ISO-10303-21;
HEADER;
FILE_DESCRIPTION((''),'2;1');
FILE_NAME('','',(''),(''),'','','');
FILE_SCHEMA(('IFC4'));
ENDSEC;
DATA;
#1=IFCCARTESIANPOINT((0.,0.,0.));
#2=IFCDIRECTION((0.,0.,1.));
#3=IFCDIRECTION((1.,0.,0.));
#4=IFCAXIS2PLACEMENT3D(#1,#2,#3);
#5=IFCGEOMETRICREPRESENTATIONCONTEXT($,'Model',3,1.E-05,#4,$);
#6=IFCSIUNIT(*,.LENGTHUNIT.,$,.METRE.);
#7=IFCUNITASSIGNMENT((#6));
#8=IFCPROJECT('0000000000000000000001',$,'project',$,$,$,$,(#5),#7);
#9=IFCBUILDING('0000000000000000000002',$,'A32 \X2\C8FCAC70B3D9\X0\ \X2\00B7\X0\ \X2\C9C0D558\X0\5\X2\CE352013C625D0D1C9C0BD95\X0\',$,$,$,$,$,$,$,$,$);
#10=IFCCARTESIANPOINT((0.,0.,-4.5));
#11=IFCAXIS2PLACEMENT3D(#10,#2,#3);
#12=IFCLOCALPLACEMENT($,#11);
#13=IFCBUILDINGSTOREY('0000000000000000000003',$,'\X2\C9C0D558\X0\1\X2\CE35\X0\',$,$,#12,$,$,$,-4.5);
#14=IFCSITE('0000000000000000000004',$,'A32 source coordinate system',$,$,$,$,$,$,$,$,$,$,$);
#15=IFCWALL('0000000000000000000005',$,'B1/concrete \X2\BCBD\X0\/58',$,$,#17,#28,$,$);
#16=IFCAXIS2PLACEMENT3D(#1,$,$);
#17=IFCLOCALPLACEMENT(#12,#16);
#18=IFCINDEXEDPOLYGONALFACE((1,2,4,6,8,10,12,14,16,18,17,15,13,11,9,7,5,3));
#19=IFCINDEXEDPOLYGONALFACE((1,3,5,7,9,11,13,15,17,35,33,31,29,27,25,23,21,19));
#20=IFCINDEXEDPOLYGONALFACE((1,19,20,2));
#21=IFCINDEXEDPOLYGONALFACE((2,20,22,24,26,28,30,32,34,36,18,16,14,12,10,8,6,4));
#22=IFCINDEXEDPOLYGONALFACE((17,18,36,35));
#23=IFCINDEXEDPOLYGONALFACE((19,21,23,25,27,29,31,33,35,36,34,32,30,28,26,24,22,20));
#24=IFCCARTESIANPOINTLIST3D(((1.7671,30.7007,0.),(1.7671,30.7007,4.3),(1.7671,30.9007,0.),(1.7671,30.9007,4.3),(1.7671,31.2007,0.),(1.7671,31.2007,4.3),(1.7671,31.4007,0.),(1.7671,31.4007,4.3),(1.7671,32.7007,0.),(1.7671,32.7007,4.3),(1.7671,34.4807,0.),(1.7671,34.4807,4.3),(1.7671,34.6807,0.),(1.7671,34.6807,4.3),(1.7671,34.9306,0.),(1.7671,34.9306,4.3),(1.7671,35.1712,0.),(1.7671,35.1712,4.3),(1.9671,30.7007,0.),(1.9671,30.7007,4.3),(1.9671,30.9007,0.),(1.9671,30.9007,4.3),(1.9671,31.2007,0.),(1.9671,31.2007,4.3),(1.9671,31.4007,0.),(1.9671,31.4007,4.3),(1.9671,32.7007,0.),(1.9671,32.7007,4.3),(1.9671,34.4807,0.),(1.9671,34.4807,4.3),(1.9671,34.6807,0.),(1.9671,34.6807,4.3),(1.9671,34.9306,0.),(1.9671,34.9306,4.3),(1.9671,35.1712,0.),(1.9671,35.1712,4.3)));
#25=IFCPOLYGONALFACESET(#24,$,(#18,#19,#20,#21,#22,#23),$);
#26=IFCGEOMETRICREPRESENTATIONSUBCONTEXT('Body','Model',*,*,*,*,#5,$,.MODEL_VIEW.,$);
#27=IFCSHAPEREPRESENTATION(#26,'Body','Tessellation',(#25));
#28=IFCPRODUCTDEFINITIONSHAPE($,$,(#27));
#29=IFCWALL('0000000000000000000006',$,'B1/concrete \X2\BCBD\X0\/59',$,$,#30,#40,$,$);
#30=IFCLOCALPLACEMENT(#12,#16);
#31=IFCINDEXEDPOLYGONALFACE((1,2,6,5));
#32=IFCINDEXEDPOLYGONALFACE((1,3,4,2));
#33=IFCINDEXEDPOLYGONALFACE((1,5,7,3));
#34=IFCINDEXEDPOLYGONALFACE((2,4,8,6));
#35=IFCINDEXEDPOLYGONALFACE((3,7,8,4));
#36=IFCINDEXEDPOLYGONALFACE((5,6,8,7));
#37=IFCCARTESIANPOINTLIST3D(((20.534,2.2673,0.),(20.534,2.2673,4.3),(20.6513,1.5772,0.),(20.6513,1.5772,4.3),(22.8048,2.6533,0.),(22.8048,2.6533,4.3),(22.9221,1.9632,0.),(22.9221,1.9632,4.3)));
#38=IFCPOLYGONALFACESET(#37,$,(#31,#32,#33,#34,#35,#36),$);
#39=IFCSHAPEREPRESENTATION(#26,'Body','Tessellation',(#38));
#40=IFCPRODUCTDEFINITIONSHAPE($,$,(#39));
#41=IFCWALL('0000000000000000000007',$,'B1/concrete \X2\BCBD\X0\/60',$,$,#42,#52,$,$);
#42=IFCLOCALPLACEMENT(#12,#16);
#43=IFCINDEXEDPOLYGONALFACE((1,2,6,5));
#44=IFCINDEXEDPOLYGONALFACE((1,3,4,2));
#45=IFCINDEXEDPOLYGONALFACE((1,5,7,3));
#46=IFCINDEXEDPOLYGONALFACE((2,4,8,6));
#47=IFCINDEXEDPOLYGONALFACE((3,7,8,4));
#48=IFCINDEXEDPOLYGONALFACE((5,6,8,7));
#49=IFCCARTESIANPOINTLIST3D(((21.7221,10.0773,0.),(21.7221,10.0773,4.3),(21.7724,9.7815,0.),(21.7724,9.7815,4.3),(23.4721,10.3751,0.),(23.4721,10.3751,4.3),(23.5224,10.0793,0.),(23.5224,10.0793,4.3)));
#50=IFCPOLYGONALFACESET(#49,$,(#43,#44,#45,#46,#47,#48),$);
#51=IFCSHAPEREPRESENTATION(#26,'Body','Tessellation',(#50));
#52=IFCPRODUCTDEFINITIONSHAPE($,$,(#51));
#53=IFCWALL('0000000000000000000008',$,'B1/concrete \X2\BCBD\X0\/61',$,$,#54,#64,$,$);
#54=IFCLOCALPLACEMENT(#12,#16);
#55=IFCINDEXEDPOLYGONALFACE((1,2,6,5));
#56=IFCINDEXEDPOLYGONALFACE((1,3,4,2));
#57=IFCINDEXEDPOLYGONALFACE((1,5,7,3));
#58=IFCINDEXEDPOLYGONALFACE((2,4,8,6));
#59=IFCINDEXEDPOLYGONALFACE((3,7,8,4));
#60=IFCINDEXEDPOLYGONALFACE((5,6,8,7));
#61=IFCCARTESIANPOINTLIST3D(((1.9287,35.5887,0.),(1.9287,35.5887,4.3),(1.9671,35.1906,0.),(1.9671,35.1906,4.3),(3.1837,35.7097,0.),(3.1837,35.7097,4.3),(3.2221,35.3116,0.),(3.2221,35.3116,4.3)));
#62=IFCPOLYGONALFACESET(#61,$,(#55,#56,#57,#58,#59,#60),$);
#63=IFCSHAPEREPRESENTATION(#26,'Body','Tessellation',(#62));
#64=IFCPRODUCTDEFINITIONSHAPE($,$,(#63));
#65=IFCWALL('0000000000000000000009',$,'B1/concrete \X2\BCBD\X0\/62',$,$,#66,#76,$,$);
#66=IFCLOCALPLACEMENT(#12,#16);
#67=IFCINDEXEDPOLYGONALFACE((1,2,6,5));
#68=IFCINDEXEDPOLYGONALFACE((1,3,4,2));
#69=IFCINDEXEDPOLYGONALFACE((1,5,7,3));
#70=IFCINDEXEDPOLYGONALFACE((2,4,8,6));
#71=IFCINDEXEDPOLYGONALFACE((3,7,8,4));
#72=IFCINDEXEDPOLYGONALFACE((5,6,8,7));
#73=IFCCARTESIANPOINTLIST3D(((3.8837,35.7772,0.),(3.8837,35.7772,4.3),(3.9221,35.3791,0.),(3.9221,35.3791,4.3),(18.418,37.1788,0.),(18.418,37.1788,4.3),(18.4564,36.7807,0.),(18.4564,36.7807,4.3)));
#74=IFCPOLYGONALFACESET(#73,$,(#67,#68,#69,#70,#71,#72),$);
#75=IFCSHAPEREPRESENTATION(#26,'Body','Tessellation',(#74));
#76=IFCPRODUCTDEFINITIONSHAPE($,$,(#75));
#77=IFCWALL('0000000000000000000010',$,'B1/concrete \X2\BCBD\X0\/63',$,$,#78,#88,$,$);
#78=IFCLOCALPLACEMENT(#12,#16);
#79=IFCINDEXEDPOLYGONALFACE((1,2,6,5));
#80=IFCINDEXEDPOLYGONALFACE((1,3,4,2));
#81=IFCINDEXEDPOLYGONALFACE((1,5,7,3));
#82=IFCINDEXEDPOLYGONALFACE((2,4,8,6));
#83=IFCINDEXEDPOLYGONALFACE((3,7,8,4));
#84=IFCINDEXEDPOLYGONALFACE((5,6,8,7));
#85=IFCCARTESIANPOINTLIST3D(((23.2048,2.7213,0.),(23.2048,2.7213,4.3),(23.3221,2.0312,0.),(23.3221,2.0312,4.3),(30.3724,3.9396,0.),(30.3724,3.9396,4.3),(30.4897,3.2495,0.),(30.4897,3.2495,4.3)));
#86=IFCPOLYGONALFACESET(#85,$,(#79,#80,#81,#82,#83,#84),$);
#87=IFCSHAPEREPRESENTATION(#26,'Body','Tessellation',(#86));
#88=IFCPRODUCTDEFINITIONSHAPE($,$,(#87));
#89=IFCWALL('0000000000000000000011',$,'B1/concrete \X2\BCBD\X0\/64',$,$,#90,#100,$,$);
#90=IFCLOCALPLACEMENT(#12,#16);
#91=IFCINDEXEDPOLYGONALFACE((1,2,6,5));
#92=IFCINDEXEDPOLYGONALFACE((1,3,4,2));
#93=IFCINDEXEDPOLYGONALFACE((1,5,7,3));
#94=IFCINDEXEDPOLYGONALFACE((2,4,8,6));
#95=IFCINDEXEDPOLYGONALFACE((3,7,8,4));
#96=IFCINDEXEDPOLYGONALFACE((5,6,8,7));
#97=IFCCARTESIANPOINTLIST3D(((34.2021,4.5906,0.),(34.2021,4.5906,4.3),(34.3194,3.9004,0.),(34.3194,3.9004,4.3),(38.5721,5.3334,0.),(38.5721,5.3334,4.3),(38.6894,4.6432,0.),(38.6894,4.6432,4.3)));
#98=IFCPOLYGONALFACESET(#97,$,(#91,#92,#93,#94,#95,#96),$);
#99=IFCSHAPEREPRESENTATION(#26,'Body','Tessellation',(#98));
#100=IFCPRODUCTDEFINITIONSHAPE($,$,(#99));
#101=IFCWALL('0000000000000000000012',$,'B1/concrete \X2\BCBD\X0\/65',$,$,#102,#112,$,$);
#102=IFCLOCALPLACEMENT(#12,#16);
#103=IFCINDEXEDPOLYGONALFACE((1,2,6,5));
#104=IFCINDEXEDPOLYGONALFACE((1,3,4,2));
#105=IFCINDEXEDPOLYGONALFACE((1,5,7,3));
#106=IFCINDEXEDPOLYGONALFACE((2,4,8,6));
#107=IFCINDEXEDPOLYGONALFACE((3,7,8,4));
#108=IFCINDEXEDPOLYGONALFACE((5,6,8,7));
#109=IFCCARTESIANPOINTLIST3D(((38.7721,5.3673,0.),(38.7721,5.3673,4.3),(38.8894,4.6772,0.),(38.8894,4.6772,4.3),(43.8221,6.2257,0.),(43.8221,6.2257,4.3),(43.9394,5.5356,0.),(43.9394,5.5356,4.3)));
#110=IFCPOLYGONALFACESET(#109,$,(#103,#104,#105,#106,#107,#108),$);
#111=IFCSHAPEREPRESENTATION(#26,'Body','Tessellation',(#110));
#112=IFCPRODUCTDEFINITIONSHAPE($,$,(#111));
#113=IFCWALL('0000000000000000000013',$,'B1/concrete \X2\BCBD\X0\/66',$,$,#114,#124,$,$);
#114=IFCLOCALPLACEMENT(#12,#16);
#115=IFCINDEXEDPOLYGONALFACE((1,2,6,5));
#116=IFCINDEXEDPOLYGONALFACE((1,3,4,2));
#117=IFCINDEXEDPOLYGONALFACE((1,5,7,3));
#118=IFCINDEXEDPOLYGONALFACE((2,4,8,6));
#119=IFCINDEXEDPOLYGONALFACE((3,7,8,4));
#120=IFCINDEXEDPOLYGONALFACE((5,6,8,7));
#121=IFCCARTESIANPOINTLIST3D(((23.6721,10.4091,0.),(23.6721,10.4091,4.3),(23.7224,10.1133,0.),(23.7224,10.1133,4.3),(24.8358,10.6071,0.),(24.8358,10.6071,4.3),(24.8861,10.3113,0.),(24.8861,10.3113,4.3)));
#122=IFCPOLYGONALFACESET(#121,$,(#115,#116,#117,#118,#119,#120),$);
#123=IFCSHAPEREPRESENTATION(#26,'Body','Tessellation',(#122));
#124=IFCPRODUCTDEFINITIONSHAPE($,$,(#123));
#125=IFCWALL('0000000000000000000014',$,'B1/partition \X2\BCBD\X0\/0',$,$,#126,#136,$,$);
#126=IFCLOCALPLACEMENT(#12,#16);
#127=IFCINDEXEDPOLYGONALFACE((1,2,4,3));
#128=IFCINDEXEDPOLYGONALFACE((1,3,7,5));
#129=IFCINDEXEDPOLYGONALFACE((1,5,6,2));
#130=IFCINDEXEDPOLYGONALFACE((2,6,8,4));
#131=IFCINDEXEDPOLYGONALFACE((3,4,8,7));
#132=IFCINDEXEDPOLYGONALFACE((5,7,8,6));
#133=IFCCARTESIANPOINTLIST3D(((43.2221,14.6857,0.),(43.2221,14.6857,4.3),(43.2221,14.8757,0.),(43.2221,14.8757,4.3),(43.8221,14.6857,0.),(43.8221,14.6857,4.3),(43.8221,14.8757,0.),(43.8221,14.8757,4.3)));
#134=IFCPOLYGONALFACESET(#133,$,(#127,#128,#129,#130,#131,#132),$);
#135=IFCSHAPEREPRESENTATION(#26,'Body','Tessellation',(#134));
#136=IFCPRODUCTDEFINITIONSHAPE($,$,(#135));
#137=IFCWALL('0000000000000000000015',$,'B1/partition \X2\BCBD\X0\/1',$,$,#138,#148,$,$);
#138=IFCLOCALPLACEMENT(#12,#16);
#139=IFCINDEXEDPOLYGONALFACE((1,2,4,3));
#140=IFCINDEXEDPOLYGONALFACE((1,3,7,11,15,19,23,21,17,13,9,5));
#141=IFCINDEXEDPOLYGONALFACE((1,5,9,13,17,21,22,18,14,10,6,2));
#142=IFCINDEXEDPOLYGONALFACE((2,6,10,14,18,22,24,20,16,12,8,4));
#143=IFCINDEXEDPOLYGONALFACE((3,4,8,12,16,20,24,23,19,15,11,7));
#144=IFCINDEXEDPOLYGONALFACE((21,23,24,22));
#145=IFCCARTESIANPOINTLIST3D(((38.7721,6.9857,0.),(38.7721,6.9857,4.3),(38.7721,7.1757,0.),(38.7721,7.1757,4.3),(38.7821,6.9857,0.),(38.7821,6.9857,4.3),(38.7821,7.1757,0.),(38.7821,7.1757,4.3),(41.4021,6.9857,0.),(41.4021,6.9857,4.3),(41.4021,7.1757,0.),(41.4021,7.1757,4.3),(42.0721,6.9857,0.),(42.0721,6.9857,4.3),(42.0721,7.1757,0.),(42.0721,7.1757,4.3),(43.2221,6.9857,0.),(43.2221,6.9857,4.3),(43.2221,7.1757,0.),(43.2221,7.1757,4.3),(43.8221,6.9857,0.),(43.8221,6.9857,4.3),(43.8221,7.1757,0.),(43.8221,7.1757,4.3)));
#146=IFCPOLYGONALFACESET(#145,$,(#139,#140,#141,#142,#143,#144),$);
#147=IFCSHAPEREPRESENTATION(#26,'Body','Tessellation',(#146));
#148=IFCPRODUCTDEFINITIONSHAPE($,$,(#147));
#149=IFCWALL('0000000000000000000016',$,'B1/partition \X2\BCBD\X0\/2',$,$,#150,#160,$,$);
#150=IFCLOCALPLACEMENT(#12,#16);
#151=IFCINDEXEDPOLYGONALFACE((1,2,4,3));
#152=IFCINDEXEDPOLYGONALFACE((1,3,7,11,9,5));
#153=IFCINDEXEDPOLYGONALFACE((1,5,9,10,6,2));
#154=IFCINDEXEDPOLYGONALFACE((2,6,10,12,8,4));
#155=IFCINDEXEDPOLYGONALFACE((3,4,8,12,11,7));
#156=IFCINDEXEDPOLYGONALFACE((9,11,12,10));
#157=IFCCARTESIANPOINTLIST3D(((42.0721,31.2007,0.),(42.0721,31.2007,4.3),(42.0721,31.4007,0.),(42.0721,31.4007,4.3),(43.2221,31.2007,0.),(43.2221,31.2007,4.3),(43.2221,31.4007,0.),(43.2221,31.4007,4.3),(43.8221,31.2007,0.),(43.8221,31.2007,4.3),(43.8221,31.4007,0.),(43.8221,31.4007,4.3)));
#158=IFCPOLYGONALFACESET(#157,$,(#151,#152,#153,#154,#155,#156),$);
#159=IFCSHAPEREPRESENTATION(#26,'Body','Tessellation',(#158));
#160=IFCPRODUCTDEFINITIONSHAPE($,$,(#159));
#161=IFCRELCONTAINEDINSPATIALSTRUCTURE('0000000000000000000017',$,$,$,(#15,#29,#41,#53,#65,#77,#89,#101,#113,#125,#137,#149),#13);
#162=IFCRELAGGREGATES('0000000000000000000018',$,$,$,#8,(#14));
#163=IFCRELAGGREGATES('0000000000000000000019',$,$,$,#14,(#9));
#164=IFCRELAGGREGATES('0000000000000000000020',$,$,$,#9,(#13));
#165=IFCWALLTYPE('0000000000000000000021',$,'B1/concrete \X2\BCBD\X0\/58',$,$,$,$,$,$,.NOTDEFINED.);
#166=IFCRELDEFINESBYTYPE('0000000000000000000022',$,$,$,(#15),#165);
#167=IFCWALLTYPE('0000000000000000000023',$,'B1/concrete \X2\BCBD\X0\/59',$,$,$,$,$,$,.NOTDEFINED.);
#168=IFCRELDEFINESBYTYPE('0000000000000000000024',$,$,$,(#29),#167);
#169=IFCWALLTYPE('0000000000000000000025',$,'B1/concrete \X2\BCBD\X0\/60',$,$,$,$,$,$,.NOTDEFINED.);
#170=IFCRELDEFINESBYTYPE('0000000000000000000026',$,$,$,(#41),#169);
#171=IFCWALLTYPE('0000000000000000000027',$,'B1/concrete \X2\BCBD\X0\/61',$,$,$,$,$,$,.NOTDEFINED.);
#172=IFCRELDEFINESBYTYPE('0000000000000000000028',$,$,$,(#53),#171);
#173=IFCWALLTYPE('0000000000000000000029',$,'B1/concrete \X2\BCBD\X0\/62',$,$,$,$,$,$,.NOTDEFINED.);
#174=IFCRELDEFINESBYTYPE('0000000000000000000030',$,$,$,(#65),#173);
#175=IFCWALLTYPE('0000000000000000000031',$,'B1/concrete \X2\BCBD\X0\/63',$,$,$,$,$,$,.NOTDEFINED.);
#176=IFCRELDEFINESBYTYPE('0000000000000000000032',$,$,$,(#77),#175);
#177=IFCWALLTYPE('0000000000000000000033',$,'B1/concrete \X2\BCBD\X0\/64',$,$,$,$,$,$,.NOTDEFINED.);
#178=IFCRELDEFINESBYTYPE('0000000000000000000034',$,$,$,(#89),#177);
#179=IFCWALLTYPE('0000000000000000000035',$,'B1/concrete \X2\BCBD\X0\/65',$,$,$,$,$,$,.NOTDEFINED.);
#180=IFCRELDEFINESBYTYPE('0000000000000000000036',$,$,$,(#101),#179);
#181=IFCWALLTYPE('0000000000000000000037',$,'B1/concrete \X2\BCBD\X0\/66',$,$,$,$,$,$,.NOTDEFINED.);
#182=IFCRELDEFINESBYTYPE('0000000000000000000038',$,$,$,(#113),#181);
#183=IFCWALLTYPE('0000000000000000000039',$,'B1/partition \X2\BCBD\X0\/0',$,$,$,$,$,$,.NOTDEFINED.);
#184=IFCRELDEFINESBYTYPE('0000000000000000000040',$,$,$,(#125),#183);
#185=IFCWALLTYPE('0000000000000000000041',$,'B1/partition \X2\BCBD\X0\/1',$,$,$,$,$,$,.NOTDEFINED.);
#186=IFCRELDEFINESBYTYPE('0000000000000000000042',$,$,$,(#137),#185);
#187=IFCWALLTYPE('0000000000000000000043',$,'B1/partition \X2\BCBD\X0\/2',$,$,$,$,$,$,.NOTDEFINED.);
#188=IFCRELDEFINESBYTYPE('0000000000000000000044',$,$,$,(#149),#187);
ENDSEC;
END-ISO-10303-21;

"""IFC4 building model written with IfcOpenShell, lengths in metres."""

from ifc_helpers import new_model, si_unit, frame, origin, origin_with_axes, place, context, subcontext, project, spatial, polyline, outline, extrude, source, transform, mapped, type_object, type_shapes, element, save


model = new_model("IFC4")

# Units and contexts
model_context = context("Model", 3, precision=1e-05, world=origin_with_axes())
body_context = subcontext(model_context, "Body", "Model", "MODEL_VIEW")
ifc_project = project(units=[si_unit("LENGTHUNIT", "METRE")], contexts=[model_context])

# Site, building, storey
site = spatial("IfcSite", under=ifc_project, Name="A32 source coordinate system")
building = spatial("IfcBuilding", under=site, Name="A32 주거동 · 지하5층–옥탑지붕")
storey_placement = place(None, frame((0.0, 0.0, -4.5), z_axis=(0.0, 0.0, 1.0), x_axis=(1.0, 0.0, 0.0)))
storey = spatial("IfcBuildingStorey", under=building, at=storey_placement, Name="지하1층", Elevation=-4.5)

# Walls
wall_type_1 = type_object("IfcWallType", Name="B1/concrete 벽/58", PredefinedType="NOTDEFINED")
shared_shape_1 = source(origin(), body_context, "Body", "SweptSolid", [
    extrude(outline(polyline([(1.7671, 35.1712), (1.9671, 35.1712), (1.9671, 34.9306), (1.9671, 34.6807), (1.9671, 34.4807), (1.9671, 32.7007), (1.9671, 31.4007), (1.9671, 31.2007), (1.9671, 30.9007), (1.9671, 30.7007), (1.7671, 30.7007), (1.7671, 30.9007), (1.7671, 31.2007), (1.7671, 31.4007), (1.7671, 32.7007), (1.7671, 34.4807), (1.7671, 34.6807), (1.7671, 34.9306), (1.7671, 35.1712)])), origin(), (0.0, 0.0, 1.0), 4.3),
])
type_shapes(wall_type_1, [shared_shape_1])
wall_1_placement = place(storey_placement, origin_with_axes())
element("IfcWall", 1, at=wall_1_placement, inside=storey, type_object=wall_type_1, Name="B1/concrete 벽/58", context=body_context, shape_type="MappedRepresentation", body=[
    mapped(shared_shape_1, transform((0.0, 0.0, 0.0), scale=1.0)),
])
wall_type_2 = type_object("IfcWallType", Name="B1/concrete 벽/59", PredefinedType="NOTDEFINED")
shared_shape_2 = source(origin(), body_context, "Body", "SweptSolid", [
    extrude(outline(polyline([(22.8048, 2.6533), (22.9221, 1.9632), (20.6513, 1.5772), (20.534, 2.2673), (22.8048, 2.6533)])), origin(), (0.0, 0.0, 1.0), 4.3),
])
type_shapes(wall_type_2, [shared_shape_2])
wall_2_placement = place(storey_placement, origin_with_axes())
element("IfcWall", 2, at=wall_2_placement, inside=storey, type_object=wall_type_2, Name="B1/concrete 벽/59", context=body_context, shape_type="MappedRepresentation", body=[
    mapped(shared_shape_2, transform((0.0, 0.0, 0.0), scale=1.0)),
])
wall_type_3 = type_object("IfcWallType", Name="B1/concrete 벽/60", PredefinedType="NOTDEFINED")
shared_shape_3 = source(origin(), body_context, "Body", "SweptSolid", [
    extrude(outline(polyline([(21.7221, 10.0773), (23.4721, 10.3751), (23.5224, 10.0793), (21.7724, 9.7815), (21.7221, 10.0773)])), origin(), (0.0, 0.0, 1.0), 4.3),
])
type_shapes(wall_type_3, [shared_shape_3])
wall_3_placement = place(storey_placement, origin_with_axes())
element("IfcWall", 3, at=wall_3_placement, inside=storey, type_object=wall_type_3, Name="B1/concrete 벽/60", context=body_context, shape_type="MappedRepresentation", body=[
    mapped(shared_shape_3, transform((0.0, 0.0, 0.0), scale=1.0)),
])
wall_type_4 = type_object("IfcWallType", Name="B1/concrete 벽/61", PredefinedType="NOTDEFINED")
shared_shape_4 = source(origin(), body_context, "Body", "SweptSolid", [
    extrude(outline(polyline([(1.9671, 35.1906), (1.9287, 35.5887), (3.1837, 35.7097), (3.2221, 35.3116), (1.9671, 35.1906)])), origin(), (0.0, 0.0, 1.0), 4.3),
])
type_shapes(wall_type_4, [shared_shape_4])
wall_4_placement = place(storey_placement, origin_with_axes())
element("IfcWall", 4, at=wall_4_placement, inside=storey, type_object=wall_type_4, Name="B1/concrete 벽/61", context=body_context, shape_type="MappedRepresentation", body=[
    mapped(shared_shape_4, transform((0.0, 0.0, 0.0), scale=1.0)),
])
wall_type_5 = type_object("IfcWallType", Name="B1/concrete 벽/62", PredefinedType="NOTDEFINED")
shared_shape_5 = source(origin(), body_context, "Body", "SweptSolid", [
    extrude(outline(polyline([(3.9221, 35.3791), (3.8837, 35.7772), (18.418, 37.1788), (18.4564, 36.7807), (3.9221, 35.3791)])), origin(), (0.0, 0.0, 1.0), 4.3),
])
type_shapes(wall_type_5, [shared_shape_5])
wall_5_placement = place(storey_placement, origin_with_axes())
element("IfcWall", 5, at=wall_5_placement, inside=storey, type_object=wall_type_5, Name="B1/concrete 벽/62", context=body_context, shape_type="MappedRepresentation", body=[
    mapped(shared_shape_5, transform((0.0, 0.0, 0.0), scale=1.0)),
])
wall_type_6 = type_object("IfcWallType", Name="B1/concrete 벽/63", PredefinedType="NOTDEFINED")
shared_shape_6 = source(origin(), body_context, "Body", "SweptSolid", [
    extrude(outline(polyline([(30.4897, 3.2495), (23.3221, 2.0312), (23.2048, 2.7213), (30.3724, 3.9396), (30.4897, 3.2495)])), origin(), (0.0, 0.0, 1.0), 4.3),
])
type_shapes(wall_type_6, [shared_shape_6])
wall_6_placement = place(storey_placement, origin_with_axes())
element("IfcWall", 6, at=wall_6_placement, inside=storey, type_object=wall_type_6, Name="B1/concrete 벽/63", context=body_context, shape_type="MappedRepresentation", body=[
    mapped(shared_shape_6, transform((0.0, 0.0, 0.0), scale=1.0)),
])
wall_type_7 = type_object("IfcWallType", Name="B1/concrete 벽/64", PredefinedType="NOTDEFINED")
shared_shape_7 = source(origin(), body_context, "Body", "SweptSolid", [
    extrude(outline(polyline([(38.5721, 5.3334), (38.6894, 4.6432), (34.3194, 3.9004), (34.2021, 4.5906), (38.5721, 5.3334)])), origin(), (0.0, 0.0, 1.0), 4.3),
])
type_shapes(wall_type_7, [shared_shape_7])
wall_7_placement = place(storey_placement, origin_with_axes())
element("IfcWall", 7, at=wall_7_placement, inside=storey, type_object=wall_type_7, Name="B1/concrete 벽/64", context=body_context, shape_type="MappedRepresentation", body=[
    mapped(shared_shape_7, transform((0.0, 0.0, 0.0), scale=1.0)),
])
wall_type_8 = type_object("IfcWallType", Name="B1/concrete 벽/65", PredefinedType="NOTDEFINED")
shared_shape_8 = source(origin(), body_context, "Body", "SweptSolid", [
    extrude(outline(polyline([(38.7721, 5.3673), (43.8221, 6.2257), (43.9394, 5.5356), (38.8894, 4.6772), (38.7721, 5.3673)])), origin(), (0.0, 0.0, 1.0), 4.3),
])
type_shapes(wall_type_8, [shared_shape_8])
wall_8_placement = place(storey_placement, origin_with_axes())
element("IfcWall", 8, at=wall_8_placement, inside=storey, type_object=wall_type_8, Name="B1/concrete 벽/65", context=body_context, shape_type="MappedRepresentation", body=[
    mapped(shared_shape_8, transform((0.0, 0.0, 0.0), scale=1.0)),
])
wall_type_9 = type_object("IfcWallType", Name="B1/concrete 벽/66", PredefinedType="NOTDEFINED")
shared_shape_9 = source(origin(), body_context, "Body", "SweptSolid", [
    extrude(outline(polyline([(24.8358, 10.6071), (24.8861, 10.3113), (23.7224, 10.1133), (23.6721, 10.4091), (24.8358, 10.6071)])), origin(), (0.0, 0.0, 1.0), 4.3),
])
type_shapes(wall_type_9, [shared_shape_9])
wall_9_placement = place(storey_placement, origin_with_axes())
element("IfcWall", 9, at=wall_9_placement, inside=storey, type_object=wall_type_9, Name="B1/concrete 벽/66", context=body_context, shape_type="MappedRepresentation", body=[
    mapped(shared_shape_9, transform((0.0, 0.0, 0.0), scale=1.0)),
])
wall_type_10 = type_object("IfcWallType", Name="B1/partition 벽/0", PredefinedType="NOTDEFINED")
shared_shape_10 = source(origin(), body_context, "Body", "SweptSolid", [
    extrude(outline(polyline([(43.8221, 14.6857), (43.2221, 14.6857), (43.2221, 14.8757), (43.8221, 14.8757), (43.8221, 14.6857)])), origin(), (0.0, 0.0, 1.0), 4.3),
])
type_shapes(wall_type_10, [shared_shape_10])
wall_10_placement = place(storey_placement, origin_with_axes())
element("IfcWall", 10, at=wall_10_placement, inside=storey, type_object=wall_type_10, Name="B1/partition 벽/0", context=body_context, shape_type="MappedRepresentation", body=[
    mapped(shared_shape_10, transform((0.0, 0.0, 0.0), scale=1.0)),
])
wall_type_11 = type_object("IfcWallType", Name="B1/partition 벽/1", PredefinedType="NOTDEFINED")
shared_shape_11 = source(origin(), body_context, "Body", "SweptSolid", [
    extrude(outline(polyline([(43.8221, 7.1757), (43.8221, 6.9857), (43.2221, 6.9857), (42.0721, 6.9857), (41.4021, 6.9857), (38.7821, 6.9857), (38.7721, 6.9857), (38.7721, 7.1757), (38.7821, 7.1757), (41.4021, 7.1757), (42.0721, 7.1757), (43.2221, 7.1757), (43.8221, 7.1757)])), origin(), (0.0, 0.0, 1.0), 4.3),
])
type_shapes(wall_type_11, [shared_shape_11])
wall_11_placement = place(storey_placement, origin_with_axes())
element("IfcWall", 11, at=wall_11_placement, inside=storey, type_object=wall_type_11, Name="B1/partition 벽/1", context=body_context, shape_type="MappedRepresentation", body=[
    mapped(shared_shape_11, transform((0.0, 0.0, 0.0), scale=1.0)),
])
wall_type_12 = type_object("IfcWallType", Name="B1/partition 벽/2", PredefinedType="NOTDEFINED")
shared_shape_12 = source(origin(), body_context, "Body", "SweptSolid", [
    extrude(outline(polyline([(42.0721, 31.4007), (43.2221, 31.4007), (43.8221, 31.4007), (43.8221, 31.2007), (43.2221, 31.2007), (42.0721, 31.2007), (42.0721, 31.4007)])), origin(), (0.0, 0.0, 1.0), 4.3),
])
type_shapes(wall_type_12, [shared_shape_12])
wall_12_placement = place(storey_placement, origin_with_axes())
element("IfcWall", 12, at=wall_12_placement, inside=storey, type_object=wall_type_12, Name="B1/partition 벽/2", context=body_context, shape_type="MappedRepresentation", body=[
    mapped(shared_shape_12, transform((0.0, 0.0, 0.0), scale=1.0)),
])

save(model, "model.ifc")
